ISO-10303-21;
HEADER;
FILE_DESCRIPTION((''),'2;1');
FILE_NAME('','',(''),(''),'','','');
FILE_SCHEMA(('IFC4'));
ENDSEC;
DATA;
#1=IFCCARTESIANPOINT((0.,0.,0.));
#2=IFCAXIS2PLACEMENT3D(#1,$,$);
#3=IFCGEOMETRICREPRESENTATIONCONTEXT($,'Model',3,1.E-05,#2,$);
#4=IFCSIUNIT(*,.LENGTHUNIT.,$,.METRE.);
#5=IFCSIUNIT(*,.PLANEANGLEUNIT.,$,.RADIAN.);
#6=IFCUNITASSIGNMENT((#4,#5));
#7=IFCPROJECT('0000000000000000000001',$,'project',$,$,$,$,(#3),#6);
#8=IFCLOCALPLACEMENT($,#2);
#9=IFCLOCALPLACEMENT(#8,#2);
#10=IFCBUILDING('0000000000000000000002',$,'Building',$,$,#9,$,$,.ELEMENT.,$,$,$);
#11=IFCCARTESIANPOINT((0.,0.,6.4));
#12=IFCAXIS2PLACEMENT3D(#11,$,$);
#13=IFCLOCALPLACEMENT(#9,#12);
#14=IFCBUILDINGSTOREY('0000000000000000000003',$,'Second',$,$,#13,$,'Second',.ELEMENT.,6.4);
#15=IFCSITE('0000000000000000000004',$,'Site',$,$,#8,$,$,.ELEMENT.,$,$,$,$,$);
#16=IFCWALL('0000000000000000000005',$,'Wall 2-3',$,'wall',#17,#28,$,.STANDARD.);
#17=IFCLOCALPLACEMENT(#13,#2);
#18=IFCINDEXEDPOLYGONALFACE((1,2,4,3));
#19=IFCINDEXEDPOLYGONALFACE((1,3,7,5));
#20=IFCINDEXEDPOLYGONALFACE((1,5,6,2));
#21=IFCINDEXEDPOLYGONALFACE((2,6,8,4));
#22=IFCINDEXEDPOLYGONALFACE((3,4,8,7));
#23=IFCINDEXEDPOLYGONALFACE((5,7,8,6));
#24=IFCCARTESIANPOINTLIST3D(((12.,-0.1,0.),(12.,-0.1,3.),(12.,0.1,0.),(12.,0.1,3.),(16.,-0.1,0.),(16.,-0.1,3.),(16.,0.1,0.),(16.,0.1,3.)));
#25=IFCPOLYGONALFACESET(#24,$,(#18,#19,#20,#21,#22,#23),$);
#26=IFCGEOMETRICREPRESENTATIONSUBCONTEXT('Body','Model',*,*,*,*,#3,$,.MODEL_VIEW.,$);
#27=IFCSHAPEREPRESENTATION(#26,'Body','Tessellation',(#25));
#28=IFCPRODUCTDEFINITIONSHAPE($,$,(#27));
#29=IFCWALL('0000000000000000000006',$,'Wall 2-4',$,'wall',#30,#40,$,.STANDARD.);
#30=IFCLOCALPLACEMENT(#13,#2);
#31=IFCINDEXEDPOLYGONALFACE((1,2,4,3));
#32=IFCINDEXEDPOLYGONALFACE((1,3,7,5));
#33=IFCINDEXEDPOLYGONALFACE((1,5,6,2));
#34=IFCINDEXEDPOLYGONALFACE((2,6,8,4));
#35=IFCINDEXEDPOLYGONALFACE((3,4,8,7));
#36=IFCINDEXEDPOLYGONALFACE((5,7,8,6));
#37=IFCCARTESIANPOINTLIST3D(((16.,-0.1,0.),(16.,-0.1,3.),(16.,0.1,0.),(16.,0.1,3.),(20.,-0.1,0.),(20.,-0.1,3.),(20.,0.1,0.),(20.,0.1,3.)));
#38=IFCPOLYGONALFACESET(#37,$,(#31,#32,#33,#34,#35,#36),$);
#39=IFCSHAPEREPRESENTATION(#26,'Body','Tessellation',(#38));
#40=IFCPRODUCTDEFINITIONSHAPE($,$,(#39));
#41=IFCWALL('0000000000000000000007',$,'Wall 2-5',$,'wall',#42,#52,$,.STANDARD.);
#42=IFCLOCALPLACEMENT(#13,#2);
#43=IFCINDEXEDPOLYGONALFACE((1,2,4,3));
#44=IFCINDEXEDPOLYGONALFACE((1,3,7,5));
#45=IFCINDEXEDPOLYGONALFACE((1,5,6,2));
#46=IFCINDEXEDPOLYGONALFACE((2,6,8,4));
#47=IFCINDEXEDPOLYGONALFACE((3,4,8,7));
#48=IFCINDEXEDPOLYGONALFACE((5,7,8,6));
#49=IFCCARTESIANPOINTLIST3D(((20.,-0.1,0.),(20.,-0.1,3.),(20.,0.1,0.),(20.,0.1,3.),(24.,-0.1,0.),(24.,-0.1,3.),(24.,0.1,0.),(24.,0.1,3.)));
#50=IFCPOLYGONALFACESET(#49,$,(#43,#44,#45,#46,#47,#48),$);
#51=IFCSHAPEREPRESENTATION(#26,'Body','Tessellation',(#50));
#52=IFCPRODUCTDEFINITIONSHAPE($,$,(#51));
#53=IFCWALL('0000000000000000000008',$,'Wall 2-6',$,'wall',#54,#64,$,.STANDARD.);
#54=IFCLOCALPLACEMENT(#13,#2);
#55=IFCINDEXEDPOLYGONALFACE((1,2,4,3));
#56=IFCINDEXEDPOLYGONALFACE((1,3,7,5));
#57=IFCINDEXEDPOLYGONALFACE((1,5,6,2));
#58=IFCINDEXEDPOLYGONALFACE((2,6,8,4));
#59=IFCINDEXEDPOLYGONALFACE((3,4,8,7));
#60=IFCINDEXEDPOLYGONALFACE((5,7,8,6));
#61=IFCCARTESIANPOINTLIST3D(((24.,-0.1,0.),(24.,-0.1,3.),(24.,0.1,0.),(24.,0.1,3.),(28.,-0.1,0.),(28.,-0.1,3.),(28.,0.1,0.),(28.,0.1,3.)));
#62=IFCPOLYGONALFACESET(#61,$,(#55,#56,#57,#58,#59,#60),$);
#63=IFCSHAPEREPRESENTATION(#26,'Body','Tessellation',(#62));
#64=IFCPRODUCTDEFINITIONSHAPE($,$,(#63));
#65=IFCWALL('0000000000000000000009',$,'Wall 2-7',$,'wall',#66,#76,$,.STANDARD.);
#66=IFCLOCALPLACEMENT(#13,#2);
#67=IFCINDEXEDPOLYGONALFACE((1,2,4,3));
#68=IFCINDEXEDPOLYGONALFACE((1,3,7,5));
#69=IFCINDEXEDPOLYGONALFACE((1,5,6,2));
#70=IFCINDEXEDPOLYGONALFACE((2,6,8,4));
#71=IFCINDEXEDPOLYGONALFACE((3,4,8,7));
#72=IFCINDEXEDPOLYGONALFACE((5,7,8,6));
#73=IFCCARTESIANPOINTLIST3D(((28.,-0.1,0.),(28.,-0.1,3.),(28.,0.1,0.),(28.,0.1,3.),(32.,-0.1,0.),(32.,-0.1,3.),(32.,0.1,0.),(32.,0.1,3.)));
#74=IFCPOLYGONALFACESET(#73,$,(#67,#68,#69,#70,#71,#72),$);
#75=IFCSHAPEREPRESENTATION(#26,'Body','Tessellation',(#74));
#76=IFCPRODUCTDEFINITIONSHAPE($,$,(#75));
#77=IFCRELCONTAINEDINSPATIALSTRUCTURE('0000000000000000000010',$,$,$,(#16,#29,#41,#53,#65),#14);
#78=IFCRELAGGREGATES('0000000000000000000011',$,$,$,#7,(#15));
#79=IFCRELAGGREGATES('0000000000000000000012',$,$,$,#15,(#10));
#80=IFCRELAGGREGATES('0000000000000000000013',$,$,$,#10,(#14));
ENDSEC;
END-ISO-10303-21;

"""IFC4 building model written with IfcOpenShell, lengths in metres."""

from ifc_helpers import new_model, si_unit, frame, frame_2d, origin, place, context, subcontext, project, spatial, rectangle, extrude, element, save


model = new_model("IFC4")

# Units and contexts
model_context = context("Model", 3, precision=1e-05, world=origin())
body_context = subcontext(model_context, "Body", "Model", "MODEL_VIEW")
ifc_project = project(units=[si_unit("LENGTHUNIT", "METRE"), si_unit("PLANEANGLEUNIT", "RADIAN")], contexts=[model_context])

# Site, building, storey
site_placement = place(None, origin())
site = spatial("IfcSite", under=ifc_project, at=site_placement, Name="Site", CompositionType="ELEMENT")
building_placement = place(site_placement, origin())
building = spatial("IfcBuilding", under=site, at=building_placement, Name="Building", CompositionType="ELEMENT")
storey_placement = place(building_placement, frame((0.0, 0.0, 6.4)))
storey = spatial("IfcBuildingStorey", under=building, at=storey_placement, Name="Second", LongName="Second", CompositionType="ELEMENT", Elevation=6.4)

# Walls
for number, where, z_axis, x_axis, name in (
    (1, (12.0, 0.0, 0.0), (0.0, 0.0, 1.0), (1.0, 0.0, 0.0), "Wall 2-3"),
    (2, (16.0, 0.0, 0.0), (0.0, 0.0, 1.0), (1.0, 0.0, 0.0), "Wall 2-4"),
    (3, (20.0, 0.0, 0.0), (0.0, 0.0, 1.0), (1.0, 0.0, 0.0), "Wall 2-5"),
    (4, (24.0, 0.0, 0.0), (0.0, 0.0, 1.0), (1.0, 0.0, 0.0), "Wall 2-6"),
    (5, (28.0, 0.0, 0.0), (0.0, 0.0, 1.0), (1.0, 0.0, 0.0), "Wall 2-7"),
):
    element("IfcWall", number, at=place(storey_placement, frame(where, z_axis=z_axis, x_axis=x_axis)), inside=storey, Name=name, ObjectType="wall", PredefinedType="STANDARD", context=body_context, shape_type="SweptSolid", body=[
        extrude(rectangle(XDim=4.0, YDim=0.2, at=frame_2d((2.0, 0.0))), origin(), (0.0, 0.0, 1.0), 3.0),
    ])

save(model, "model.ifc")
